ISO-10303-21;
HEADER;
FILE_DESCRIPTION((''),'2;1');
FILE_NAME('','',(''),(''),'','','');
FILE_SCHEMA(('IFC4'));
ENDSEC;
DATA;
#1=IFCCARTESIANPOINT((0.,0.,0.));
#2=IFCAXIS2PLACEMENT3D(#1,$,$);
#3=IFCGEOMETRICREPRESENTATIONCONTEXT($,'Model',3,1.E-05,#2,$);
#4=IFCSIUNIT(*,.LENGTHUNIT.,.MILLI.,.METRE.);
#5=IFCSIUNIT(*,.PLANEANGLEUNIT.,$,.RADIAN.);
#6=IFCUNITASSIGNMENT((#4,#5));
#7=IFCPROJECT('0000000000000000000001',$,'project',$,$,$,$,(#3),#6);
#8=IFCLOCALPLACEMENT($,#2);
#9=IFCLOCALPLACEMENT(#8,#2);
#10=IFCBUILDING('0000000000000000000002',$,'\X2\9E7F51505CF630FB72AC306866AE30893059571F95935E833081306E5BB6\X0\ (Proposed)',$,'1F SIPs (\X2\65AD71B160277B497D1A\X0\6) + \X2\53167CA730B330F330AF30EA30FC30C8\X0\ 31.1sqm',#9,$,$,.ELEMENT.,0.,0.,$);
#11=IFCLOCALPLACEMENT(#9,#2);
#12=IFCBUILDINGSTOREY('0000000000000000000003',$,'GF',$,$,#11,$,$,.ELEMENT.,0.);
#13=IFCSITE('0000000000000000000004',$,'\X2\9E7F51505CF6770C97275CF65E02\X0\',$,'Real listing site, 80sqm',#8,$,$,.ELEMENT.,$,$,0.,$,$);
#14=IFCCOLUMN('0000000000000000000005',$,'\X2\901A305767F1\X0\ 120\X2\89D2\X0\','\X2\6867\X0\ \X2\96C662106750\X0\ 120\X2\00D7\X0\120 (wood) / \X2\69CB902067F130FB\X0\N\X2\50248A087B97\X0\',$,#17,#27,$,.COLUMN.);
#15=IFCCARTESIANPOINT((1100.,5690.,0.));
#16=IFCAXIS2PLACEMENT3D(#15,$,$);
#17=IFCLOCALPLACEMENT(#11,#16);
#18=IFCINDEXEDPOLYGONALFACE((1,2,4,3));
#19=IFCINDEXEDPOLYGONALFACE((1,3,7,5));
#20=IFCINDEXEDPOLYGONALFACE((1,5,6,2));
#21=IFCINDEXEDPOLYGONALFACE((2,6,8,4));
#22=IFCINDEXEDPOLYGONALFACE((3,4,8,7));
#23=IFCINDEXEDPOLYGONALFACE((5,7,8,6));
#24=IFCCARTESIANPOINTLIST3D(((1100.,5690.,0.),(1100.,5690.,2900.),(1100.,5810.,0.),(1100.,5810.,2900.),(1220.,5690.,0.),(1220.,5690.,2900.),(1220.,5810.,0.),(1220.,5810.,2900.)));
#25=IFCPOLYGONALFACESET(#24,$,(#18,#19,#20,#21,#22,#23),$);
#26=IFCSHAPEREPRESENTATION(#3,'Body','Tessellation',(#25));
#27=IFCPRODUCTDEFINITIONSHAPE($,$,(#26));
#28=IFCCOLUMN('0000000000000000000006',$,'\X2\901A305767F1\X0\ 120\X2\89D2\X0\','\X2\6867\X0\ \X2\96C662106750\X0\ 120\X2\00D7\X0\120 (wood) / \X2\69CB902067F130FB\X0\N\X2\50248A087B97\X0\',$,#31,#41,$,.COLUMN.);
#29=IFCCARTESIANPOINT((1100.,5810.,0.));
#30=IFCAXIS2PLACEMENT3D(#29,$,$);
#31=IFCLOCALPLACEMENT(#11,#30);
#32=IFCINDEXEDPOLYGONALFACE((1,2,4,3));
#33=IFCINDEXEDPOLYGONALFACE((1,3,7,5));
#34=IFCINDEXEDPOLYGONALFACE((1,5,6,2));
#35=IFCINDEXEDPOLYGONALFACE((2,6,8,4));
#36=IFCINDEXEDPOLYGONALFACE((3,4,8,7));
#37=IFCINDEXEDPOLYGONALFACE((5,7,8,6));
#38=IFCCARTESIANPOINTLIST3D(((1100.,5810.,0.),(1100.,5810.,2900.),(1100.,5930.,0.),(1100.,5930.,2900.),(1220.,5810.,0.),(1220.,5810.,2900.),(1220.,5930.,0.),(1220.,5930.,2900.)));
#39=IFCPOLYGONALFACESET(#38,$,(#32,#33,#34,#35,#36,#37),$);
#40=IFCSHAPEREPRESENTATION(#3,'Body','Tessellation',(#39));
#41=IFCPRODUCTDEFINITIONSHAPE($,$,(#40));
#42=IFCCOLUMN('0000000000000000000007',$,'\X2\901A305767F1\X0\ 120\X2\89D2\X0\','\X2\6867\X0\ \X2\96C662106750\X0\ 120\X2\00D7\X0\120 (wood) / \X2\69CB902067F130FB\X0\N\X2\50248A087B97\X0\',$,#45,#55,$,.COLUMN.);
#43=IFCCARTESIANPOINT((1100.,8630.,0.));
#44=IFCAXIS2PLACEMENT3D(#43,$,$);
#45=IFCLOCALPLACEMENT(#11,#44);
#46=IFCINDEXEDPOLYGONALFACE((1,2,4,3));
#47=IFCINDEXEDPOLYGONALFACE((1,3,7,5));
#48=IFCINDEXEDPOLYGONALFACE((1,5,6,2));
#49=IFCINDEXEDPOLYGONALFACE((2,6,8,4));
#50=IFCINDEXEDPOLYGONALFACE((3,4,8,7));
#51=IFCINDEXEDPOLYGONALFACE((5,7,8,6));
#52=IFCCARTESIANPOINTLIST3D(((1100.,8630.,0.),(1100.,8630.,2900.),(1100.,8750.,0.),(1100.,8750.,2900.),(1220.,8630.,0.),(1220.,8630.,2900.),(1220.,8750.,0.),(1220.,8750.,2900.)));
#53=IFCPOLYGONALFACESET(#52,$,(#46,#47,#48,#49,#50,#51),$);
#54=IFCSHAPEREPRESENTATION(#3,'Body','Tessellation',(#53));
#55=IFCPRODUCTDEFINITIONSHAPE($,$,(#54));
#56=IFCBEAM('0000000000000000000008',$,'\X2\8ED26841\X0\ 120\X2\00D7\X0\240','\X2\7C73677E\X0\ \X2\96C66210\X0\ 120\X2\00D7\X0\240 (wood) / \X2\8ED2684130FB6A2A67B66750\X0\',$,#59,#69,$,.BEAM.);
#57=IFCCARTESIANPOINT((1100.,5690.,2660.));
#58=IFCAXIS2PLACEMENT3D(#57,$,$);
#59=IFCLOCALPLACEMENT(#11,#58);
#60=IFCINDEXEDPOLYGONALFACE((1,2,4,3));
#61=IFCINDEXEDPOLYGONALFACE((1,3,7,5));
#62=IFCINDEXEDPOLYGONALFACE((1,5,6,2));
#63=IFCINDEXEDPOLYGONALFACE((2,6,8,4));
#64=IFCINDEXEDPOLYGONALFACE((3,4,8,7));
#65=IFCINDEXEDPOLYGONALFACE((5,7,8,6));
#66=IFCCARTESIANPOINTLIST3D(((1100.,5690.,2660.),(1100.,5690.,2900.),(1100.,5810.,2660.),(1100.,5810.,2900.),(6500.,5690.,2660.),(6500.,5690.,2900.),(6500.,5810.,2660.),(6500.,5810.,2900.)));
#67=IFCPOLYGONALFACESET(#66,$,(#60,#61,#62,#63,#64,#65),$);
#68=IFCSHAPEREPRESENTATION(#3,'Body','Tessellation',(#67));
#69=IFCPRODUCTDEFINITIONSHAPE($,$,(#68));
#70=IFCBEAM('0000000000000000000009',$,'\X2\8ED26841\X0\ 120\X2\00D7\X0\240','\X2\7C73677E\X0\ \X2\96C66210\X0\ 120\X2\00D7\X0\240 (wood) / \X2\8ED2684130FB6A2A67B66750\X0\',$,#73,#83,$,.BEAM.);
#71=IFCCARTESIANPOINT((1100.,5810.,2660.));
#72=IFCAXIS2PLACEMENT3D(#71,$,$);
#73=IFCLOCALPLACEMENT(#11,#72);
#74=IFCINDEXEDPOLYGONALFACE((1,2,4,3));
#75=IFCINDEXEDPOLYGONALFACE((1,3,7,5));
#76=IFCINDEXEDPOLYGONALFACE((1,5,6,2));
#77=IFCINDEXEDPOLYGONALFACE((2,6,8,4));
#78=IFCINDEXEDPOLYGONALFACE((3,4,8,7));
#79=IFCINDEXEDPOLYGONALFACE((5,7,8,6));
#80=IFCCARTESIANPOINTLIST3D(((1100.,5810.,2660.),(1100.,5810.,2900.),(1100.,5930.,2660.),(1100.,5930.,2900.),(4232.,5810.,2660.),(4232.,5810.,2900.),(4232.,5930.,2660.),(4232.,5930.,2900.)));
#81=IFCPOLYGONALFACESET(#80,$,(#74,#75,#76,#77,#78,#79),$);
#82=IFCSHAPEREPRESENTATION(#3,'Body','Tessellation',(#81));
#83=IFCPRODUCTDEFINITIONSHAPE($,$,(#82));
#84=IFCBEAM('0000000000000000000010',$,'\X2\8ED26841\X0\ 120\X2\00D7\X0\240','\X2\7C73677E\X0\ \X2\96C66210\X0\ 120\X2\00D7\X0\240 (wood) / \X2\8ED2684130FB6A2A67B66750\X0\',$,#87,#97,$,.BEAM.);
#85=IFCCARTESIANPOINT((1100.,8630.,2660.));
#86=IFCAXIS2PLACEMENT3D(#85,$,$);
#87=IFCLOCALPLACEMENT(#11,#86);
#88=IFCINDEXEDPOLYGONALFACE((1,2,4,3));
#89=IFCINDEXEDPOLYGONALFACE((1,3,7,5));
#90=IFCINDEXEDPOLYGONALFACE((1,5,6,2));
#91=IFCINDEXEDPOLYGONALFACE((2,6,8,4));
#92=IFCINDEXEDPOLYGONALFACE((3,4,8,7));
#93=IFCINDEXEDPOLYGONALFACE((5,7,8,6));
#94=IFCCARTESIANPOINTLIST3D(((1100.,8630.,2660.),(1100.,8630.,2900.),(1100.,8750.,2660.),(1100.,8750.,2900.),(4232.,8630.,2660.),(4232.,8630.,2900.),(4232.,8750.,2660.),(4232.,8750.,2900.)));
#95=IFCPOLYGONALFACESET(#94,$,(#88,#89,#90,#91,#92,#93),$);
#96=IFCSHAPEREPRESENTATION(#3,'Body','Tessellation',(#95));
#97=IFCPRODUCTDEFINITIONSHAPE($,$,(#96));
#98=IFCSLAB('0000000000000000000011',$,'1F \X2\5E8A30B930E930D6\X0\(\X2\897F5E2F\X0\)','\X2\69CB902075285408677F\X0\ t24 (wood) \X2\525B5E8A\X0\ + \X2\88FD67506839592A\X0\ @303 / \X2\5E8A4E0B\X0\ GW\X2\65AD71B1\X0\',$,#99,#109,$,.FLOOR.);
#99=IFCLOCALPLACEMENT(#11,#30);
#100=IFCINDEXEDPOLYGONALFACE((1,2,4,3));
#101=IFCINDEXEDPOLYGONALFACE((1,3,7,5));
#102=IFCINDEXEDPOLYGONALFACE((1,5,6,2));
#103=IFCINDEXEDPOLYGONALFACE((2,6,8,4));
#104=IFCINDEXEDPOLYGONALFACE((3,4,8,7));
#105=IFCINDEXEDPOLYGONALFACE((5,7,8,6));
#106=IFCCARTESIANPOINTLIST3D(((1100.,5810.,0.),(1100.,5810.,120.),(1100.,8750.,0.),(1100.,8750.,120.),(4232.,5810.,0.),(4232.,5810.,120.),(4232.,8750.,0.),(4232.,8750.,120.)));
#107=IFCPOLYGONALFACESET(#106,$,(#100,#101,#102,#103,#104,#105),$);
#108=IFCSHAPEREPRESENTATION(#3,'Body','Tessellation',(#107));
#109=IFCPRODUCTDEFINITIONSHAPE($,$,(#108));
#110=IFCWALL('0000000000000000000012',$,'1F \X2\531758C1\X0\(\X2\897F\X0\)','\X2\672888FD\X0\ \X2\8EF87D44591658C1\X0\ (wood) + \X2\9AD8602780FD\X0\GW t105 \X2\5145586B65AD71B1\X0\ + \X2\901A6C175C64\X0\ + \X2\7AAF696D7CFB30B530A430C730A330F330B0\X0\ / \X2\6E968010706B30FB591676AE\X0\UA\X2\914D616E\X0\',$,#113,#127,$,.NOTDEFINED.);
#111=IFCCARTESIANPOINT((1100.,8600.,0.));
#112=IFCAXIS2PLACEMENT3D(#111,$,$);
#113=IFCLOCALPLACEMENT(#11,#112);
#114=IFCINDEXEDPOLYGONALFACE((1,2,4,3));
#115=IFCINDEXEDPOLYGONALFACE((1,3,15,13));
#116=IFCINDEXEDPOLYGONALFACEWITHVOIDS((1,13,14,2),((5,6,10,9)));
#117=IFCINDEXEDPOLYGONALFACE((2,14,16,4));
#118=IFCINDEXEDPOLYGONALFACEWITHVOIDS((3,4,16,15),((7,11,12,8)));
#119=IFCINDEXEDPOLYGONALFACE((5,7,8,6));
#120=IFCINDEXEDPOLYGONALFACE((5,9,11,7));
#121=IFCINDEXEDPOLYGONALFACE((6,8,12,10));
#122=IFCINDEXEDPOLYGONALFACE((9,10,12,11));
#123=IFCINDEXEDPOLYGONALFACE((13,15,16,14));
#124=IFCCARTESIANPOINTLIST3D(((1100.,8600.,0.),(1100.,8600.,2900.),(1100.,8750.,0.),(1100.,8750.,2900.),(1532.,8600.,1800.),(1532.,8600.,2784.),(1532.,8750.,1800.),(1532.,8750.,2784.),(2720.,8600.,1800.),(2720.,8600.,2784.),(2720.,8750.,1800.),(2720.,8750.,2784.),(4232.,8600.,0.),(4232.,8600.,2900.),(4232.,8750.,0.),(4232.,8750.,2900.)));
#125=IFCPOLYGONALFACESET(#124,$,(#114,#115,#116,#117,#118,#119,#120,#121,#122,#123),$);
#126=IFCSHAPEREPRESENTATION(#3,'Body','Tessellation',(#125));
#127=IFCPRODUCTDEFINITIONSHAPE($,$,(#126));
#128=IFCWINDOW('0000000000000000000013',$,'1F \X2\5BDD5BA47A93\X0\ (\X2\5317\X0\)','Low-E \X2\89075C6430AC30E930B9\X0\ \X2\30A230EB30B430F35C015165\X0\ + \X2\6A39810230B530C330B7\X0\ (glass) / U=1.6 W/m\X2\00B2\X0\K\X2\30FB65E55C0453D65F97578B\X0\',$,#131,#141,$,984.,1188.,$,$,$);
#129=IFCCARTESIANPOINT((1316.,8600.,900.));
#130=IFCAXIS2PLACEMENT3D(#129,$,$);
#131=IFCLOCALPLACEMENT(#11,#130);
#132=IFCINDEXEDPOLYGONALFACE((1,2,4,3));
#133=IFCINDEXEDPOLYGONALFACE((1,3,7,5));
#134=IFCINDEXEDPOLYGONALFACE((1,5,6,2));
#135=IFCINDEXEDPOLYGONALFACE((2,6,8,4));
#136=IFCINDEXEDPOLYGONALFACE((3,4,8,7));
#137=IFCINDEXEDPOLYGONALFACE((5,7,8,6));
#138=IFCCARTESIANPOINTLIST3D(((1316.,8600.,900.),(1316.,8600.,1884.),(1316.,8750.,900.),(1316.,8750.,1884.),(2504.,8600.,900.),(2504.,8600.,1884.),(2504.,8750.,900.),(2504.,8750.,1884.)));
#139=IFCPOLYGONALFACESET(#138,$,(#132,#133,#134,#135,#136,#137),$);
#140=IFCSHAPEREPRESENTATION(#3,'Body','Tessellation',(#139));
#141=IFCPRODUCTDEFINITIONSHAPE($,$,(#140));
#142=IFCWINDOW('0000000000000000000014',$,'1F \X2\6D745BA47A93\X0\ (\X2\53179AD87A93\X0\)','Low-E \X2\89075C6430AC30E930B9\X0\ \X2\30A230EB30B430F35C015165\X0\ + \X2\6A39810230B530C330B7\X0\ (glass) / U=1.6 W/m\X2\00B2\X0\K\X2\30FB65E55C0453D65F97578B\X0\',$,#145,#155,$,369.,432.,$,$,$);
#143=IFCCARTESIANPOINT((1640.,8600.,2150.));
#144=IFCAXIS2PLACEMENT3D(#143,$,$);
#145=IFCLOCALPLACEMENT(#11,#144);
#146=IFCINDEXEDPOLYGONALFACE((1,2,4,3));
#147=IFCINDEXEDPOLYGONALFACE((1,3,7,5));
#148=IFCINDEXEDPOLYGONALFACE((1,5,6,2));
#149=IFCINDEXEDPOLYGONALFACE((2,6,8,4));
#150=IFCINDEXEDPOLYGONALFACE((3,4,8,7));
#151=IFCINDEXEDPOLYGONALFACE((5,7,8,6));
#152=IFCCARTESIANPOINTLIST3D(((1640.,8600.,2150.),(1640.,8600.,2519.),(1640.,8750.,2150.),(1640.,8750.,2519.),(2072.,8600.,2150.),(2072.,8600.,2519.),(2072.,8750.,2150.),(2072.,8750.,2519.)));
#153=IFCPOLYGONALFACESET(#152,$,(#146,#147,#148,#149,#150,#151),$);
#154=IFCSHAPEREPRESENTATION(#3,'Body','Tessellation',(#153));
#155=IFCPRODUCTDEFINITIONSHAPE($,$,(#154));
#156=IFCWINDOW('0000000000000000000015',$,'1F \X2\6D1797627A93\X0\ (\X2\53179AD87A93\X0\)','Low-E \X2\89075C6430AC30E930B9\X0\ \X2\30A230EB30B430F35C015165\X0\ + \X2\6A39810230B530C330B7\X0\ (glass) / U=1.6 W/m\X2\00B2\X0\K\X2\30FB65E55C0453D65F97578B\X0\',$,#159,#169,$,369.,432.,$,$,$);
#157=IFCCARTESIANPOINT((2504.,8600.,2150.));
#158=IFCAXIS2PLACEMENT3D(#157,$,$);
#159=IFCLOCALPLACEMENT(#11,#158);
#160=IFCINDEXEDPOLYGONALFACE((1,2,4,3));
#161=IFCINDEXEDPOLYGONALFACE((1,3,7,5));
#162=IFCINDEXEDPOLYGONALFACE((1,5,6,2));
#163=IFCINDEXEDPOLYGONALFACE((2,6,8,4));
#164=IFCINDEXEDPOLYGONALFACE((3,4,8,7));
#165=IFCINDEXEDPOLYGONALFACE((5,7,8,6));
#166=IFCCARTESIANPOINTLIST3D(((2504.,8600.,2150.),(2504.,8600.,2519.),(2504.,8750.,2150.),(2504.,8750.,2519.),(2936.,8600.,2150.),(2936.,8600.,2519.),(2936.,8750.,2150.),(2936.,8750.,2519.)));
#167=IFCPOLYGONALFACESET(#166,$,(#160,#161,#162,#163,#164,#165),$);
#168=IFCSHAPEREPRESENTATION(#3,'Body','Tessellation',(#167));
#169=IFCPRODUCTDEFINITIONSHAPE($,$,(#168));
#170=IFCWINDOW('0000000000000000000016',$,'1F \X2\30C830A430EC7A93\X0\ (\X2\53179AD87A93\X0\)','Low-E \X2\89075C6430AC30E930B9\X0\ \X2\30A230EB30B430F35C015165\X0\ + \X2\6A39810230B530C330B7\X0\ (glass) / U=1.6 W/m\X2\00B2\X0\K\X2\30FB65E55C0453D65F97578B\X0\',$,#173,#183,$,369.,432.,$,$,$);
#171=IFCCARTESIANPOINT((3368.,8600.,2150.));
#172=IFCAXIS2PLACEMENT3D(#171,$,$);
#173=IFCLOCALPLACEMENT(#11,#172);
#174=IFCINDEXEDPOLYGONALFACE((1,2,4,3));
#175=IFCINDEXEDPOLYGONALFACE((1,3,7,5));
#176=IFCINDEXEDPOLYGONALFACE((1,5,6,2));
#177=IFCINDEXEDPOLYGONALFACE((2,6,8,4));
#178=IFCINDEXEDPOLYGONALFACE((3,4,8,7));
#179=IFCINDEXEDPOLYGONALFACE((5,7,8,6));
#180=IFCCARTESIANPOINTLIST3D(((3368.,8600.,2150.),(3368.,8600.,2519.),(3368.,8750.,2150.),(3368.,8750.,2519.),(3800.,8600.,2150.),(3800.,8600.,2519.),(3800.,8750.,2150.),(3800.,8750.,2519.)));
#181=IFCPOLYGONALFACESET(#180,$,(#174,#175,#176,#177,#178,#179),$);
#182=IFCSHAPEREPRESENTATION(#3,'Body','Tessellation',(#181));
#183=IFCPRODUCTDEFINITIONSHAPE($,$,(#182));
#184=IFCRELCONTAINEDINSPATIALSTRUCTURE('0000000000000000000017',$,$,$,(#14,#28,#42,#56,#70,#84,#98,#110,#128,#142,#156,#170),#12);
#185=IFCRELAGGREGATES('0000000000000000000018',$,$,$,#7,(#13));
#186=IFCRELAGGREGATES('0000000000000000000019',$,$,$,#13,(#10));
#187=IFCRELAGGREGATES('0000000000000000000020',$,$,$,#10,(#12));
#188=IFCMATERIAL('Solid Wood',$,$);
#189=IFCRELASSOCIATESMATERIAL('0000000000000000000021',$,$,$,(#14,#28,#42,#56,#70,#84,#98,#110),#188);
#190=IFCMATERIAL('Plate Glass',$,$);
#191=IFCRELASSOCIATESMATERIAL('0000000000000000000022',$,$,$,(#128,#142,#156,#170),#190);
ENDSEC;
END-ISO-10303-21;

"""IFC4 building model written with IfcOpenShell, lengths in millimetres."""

from ifc_helpers import new_model, si_unit, frame, frame_2d, origin, place, context, project, spatial, rectangle, extrude, material, element, fill, save


model = new_model("IFC4")

# Units and contexts
model_context = context("Model", 3, precision=1e-05, world=origin())
ifc_project = project(units=[si_unit("LENGTHUNIT", "METRE", prefix="MILLI"), si_unit("PLANEANGLEUNIT", "RADIAN")], contexts=[model_context])

# Site, building, storey
site_placement = place(None, origin())
site = spatial("IfcSite", under=ifc_project, at=site_placement, Name="鹿児島県霧島市", ObjectType="Real listing site, 80sqm", CompositionType="ELEMENT", RefElevation=0.0)
building_placement = place(site_placement, origin())
building = spatial("IfcBuilding", under=site, at=building_placement, Name="鹿児島・犬と暮らす土間広めの家 (Proposed)", ObjectType="1F SIPs (断熱性等級6) + 化粧コンクリート 31.1sqm", CompositionType="ELEMENT", ElevationOfRefHeight=0.0, ElevationOfTerrain=0.0)
storey_placement = place(building_placement, origin())
storey = spatial("IfcBuildingStorey", under=building, at=storey_placement, Name="GF", CompositionType="ELEMENT", Elevation=0.0)

# Columns
ifc_material_1 = material(Name="Solid Wood")
column_1_placement = place(storey_placement, frame((1100.0, 5690.0, 0.0)))
element("IfcColumn", 1, at=column_1_placement, inside=storey, material=ifc_material_1, Name="通し柱 120角", Description="桧 集成材 120×120 (wood) / 構造柱・N値計算", PredefinedType="COLUMN", context=model_context, shape_type="SweptSolid", body=[
    extrude(rectangle(XDim=120.0, YDim=120.0, at=frame_2d((60.0, 60.0))), frame((1100.0, 5690.0, 0.0)), (0.0, 0.0, 1.0), 2900.0),
])
column_2_placement = place(storey_placement, frame((1100.0, 5810.0, 0.0)))
element("IfcColumn", 2, at=column_2_placement, inside=storey, material=ifc_material_1, Name="通し柱 120角", Description="桧 集成材 120×120 (wood) / 構造柱・N値計算", PredefinedType="COLUMN", context=model_context, shape_type="SweptSolid", body=[
    extrude(rectangle(XDim=120.0, YDim=120.0, at=frame_2d((60.0, 60.0))), frame((1100.0, 5810.0, 0.0)), (0.0, 0.0, 1.0), 2900.0),
])
column_3_placement = place(storey_placement, frame((1100.0, 8630.0, 0.0)))
element("IfcColumn", 3, at=column_3_placement, inside=storey, material=ifc_material_1, Name="通し柱 120角", Description="桧 集成材 120×120 (wood) / 構造柱・N値計算", PredefinedType="COLUMN", context=model_context, shape_type="SweptSolid", body=[
    extrude(rectangle(XDim=120.0, YDim=120.0, at=frame_2d((60.0, 60.0))), frame((1100.0, 8630.0, 0.0)), (0.0, 0.0, 1.0), 2900.0),
])

# Beams
beam_1_placement = place(storey_placement, frame((1100.0, 5690.0, 2660.0)))
element("IfcBeam", 4, at=beam_1_placement, inside=storey, material=ifc_material_1, Name="軒桁 120×240", Description="米松 集成 120×240 (wood) / 軒桁・横架材", PredefinedType="BEAM", context=model_context, shape_type="SweptSolid", body=[
    extrude(rectangle(XDim=5400.0, YDim=120.0, at=frame_2d((2700.0, 60.0))), frame((1100.0, 5690.0, 2660.0)), (0.0, 0.0, 1.0), 240.0),
])
beam_2_placement = place(storey_placement, frame((1100.0, 5810.0, 2660.0)))
element("IfcBeam", 5, at=beam_2_placement, inside=storey, material=ifc_material_1, Name="軒桁 120×240", Description="米松 集成 120×240 (wood) / 軒桁・横架材", PredefinedType="BEAM", context=model_context, shape_type="SweptSolid", body=[
    extrude(rectangle(XDim=3132.0, YDim=120.0, at=frame_2d((1566.0, 60.0))), frame((1100.0, 5810.0, 2660.0)), (0.0, 0.0, 1.0), 240.0),
])
beam_3_placement = place(storey_placement, frame((1100.0, 8630.0, 2660.0)))
element("IfcBeam", 6, at=beam_3_placement, inside=storey, material=ifc_material_1, Name="軒桁 120×240", Description="米松 集成 120×240 (wood) / 軒桁・横架材", PredefinedType="BEAM", context=model_context, shape_type="SweptSolid", body=[
    extrude(rectangle(XDim=3132.0, YDim=120.0, at=frame_2d((1566.0, 60.0))), frame((1100.0, 8630.0, 2660.0)), (0.0, 0.0, 1.0), 240.0),
])

# Slab
slab_placement = place(storey_placement, frame((1100.0, 5810.0, 0.0)))
element("IfcSlab", 7, at=slab_placement, inside=storey, material=ifc_material_1, Name="1F 床スラブ(西帯)", Description="構造用合板 t24 (wood) 剛床 + 製材根太 @303 / 床下 GW断熱", PredefinedType="FLOOR", context=model_context, shape_type="SweptSolid", body=[
    extrude(rectangle(XDim=3132.0, YDim=2940.0, at=frame_2d((1566.0, 1470.0))), frame((1100.0, 5810.0, 0.0)), (0.0, 0.0, 1.0), 120.0),
])

# Wall, openings, windows
wall_1_placement = place(storey_placement, frame((1100.0, 8600.0, 0.0)))
wall_1 = element("IfcWall", 8, at=wall_1_placement, inside=storey, material=ifc_material_1, Name="1F 北壁(西)", Description="木製 軸組外壁 (wood) + 高性能GW t105 充填断熱 + 通気層 + 窯業系サイディング / 準耐火・外皮UA配慮", PredefinedType="NOTDEFINED", context=model_context, shape_type="SweptSolid", body=[
    extrude(rectangle(XDim=3132.0, YDim=150.0, at=frame_2d((1566.0, 75.0))), frame((1100.0, 8600.0, 0.0)), (0.0, 0.0, 1.0), 2900.0),
])
opening_1_placement = place(storey_placement, frame((1316.0, 8600.0, 900.0)))
opening_1 = element("IfcOpeningElement", 9, at=opening_1_placement, cuts=wall_1, PredefinedType="NOTDEFINED", context=model_context, shape_type="SweptSolid", body=[
    extrude(rectangle(XDim=1188.0, YDim=150.0, at=frame_2d((594.0, 75.0))), frame((1316.0, 8600.0, 900.0)), (0.0, 0.0, 1.0), 984.0),
])
opening_2_placement = place(storey_placement, frame((1640.0, 8600.0, 2150.0)))
opening_2 = element("IfcOpeningElement", 10, at=opening_2_placement, cuts=wall_1, PredefinedType="NOTDEFINED", context=model_context, shape_type="SweptSolid", body=[
    extrude(rectangle(XDim=432.0, YDim=150.0, at=frame_2d((216.0, 75.0))), frame((1640.0, 8600.0, 2150.0)), (0.0, 0.0, 1.0), 369.0),
])
opening_3_placement = place(storey_placement, frame((2504.0, 8600.0, 2150.0)))
opening_3 = element("IfcOpeningElement", 11, at=opening_3_placement, cuts=wall_1, PredefinedType="NOTDEFINED", context=model_context, shape_type="SweptSolid", body=[
    extrude(rectangle(XDim=432.0, YDim=150.0, at=frame_2d((216.0, 75.0))), frame((2504.0, 8600.0, 2150.0)), (0.0, 0.0, 1.0), 369.0),
])
opening_4_placement = place(storey_placement, frame((3368.0, 8600.0, 2150.0)))
opening_4 = element("IfcOpeningElement", 12, at=opening_4_placement, cuts=wall_1, PredefinedType="NOTDEFINED", context=model_context, shape_type="SweptSolid", body=[
    extrude(rectangle(XDim=432.0, YDim=150.0, at=frame_2d((216.0, 75.0))), frame((3368.0, 8600.0, 2150.0)), (0.0, 0.0, 1.0), 369.0),
])
ifc_material_2 = material(Name="Plate Glass")
window_1_placement = place(storey_placement, frame((1316.0, 8600.0, 900.0)))
window_1 = element("IfcWindow", 13, at=window_1_placement, inside=storey, material=ifc_material_2, Name="1F 寝室窓 (北)", Description="Low-E 複層ガラス アルゴン封入 + 樹脂サッシ (glass) / U=1.6 W/m²K・日射取得型", OverallHeight=984.0, OverallWidth=1188.0, context=model_context, shape_type="SweptSolid", body=[
    extrude(rectangle(XDim=1188.0, YDim=150.0, at=frame_2d((594.0, 75.0))), frame((1316.0, 8600.0, 900.0)), (0.0, 0.0, 1.0), 984.0),
])
fill(opening_1, window_1)
window_2_placement = place(storey_placement, frame((1640.0, 8600.0, 2150.0)))
window_2 = element("IfcWindow", 14, at=window_2_placement, inside=storey, material=ifc_material_2, Name="1F 浴室窓 (北高窓)", Description="Low-E 複層ガラス アルゴン封入 + 樹脂サッシ (glass) / U=1.6 W/m²K・日射取得型", OverallHeight=369.0, OverallWidth=432.0, context=model_context, shape_type="SweptSolid", body=[
    extrude(rectangle(XDim=432.0, YDim=150.0, at=frame_2d((216.0, 75.0))), frame((1640.0, 8600.0, 2150.0)), (0.0, 0.0, 1.0), 369.0),
])
fill(opening_2, window_2)
window_3_placement = place(storey_placement, frame((2504.0, 8600.0, 2150.0)))
window_3 = element("IfcWindow", 15, at=window_3_placement, inside=storey, material=ifc_material_2, Name="1F 洗面窓 (北高窓)", Description="Low-E 複層ガラス アルゴン封入 + 樹脂サッシ (glass) / U=1.6 W/m²K・日射取得型", OverallHeight=369.0, OverallWidth=432.0, context=model_context, shape_type="SweptSolid", body=[
    extrude(rectangle(XDim=432.0, YDim=150.0, at=frame_2d((216.0, 75.0))), frame((2504.0, 8600.0, 2150.0)), (0.0, 0.0, 1.0), 369.0),
])
fill(opening_3, window_3)
window_4_placement = place(storey_placement, frame((3368.0, 8600.0, 2150.0)))
window_4 = element("IfcWindow", 16, at=window_4_placement, inside=storey, material=ifc_material_2, Name="1F トイレ窓 (北高窓)", Description="Low-E 複層ガラス アルゴン封入 + 樹脂サッシ (glass) / U=1.6 W/m²K・日射取得型", OverallHeight=369.0, OverallWidth=432.0, context=model_context, shape_type="SweptSolid", body=[
    extrude(rectangle(XDim=432.0, YDim=150.0, at=frame_2d((216.0, 75.0))), frame((3368.0, 8600.0, 2150.0)), (0.0, 0.0, 1.0), 369.0),
])
fill(opening_4, window_4)

save(model, "model.ifc")
